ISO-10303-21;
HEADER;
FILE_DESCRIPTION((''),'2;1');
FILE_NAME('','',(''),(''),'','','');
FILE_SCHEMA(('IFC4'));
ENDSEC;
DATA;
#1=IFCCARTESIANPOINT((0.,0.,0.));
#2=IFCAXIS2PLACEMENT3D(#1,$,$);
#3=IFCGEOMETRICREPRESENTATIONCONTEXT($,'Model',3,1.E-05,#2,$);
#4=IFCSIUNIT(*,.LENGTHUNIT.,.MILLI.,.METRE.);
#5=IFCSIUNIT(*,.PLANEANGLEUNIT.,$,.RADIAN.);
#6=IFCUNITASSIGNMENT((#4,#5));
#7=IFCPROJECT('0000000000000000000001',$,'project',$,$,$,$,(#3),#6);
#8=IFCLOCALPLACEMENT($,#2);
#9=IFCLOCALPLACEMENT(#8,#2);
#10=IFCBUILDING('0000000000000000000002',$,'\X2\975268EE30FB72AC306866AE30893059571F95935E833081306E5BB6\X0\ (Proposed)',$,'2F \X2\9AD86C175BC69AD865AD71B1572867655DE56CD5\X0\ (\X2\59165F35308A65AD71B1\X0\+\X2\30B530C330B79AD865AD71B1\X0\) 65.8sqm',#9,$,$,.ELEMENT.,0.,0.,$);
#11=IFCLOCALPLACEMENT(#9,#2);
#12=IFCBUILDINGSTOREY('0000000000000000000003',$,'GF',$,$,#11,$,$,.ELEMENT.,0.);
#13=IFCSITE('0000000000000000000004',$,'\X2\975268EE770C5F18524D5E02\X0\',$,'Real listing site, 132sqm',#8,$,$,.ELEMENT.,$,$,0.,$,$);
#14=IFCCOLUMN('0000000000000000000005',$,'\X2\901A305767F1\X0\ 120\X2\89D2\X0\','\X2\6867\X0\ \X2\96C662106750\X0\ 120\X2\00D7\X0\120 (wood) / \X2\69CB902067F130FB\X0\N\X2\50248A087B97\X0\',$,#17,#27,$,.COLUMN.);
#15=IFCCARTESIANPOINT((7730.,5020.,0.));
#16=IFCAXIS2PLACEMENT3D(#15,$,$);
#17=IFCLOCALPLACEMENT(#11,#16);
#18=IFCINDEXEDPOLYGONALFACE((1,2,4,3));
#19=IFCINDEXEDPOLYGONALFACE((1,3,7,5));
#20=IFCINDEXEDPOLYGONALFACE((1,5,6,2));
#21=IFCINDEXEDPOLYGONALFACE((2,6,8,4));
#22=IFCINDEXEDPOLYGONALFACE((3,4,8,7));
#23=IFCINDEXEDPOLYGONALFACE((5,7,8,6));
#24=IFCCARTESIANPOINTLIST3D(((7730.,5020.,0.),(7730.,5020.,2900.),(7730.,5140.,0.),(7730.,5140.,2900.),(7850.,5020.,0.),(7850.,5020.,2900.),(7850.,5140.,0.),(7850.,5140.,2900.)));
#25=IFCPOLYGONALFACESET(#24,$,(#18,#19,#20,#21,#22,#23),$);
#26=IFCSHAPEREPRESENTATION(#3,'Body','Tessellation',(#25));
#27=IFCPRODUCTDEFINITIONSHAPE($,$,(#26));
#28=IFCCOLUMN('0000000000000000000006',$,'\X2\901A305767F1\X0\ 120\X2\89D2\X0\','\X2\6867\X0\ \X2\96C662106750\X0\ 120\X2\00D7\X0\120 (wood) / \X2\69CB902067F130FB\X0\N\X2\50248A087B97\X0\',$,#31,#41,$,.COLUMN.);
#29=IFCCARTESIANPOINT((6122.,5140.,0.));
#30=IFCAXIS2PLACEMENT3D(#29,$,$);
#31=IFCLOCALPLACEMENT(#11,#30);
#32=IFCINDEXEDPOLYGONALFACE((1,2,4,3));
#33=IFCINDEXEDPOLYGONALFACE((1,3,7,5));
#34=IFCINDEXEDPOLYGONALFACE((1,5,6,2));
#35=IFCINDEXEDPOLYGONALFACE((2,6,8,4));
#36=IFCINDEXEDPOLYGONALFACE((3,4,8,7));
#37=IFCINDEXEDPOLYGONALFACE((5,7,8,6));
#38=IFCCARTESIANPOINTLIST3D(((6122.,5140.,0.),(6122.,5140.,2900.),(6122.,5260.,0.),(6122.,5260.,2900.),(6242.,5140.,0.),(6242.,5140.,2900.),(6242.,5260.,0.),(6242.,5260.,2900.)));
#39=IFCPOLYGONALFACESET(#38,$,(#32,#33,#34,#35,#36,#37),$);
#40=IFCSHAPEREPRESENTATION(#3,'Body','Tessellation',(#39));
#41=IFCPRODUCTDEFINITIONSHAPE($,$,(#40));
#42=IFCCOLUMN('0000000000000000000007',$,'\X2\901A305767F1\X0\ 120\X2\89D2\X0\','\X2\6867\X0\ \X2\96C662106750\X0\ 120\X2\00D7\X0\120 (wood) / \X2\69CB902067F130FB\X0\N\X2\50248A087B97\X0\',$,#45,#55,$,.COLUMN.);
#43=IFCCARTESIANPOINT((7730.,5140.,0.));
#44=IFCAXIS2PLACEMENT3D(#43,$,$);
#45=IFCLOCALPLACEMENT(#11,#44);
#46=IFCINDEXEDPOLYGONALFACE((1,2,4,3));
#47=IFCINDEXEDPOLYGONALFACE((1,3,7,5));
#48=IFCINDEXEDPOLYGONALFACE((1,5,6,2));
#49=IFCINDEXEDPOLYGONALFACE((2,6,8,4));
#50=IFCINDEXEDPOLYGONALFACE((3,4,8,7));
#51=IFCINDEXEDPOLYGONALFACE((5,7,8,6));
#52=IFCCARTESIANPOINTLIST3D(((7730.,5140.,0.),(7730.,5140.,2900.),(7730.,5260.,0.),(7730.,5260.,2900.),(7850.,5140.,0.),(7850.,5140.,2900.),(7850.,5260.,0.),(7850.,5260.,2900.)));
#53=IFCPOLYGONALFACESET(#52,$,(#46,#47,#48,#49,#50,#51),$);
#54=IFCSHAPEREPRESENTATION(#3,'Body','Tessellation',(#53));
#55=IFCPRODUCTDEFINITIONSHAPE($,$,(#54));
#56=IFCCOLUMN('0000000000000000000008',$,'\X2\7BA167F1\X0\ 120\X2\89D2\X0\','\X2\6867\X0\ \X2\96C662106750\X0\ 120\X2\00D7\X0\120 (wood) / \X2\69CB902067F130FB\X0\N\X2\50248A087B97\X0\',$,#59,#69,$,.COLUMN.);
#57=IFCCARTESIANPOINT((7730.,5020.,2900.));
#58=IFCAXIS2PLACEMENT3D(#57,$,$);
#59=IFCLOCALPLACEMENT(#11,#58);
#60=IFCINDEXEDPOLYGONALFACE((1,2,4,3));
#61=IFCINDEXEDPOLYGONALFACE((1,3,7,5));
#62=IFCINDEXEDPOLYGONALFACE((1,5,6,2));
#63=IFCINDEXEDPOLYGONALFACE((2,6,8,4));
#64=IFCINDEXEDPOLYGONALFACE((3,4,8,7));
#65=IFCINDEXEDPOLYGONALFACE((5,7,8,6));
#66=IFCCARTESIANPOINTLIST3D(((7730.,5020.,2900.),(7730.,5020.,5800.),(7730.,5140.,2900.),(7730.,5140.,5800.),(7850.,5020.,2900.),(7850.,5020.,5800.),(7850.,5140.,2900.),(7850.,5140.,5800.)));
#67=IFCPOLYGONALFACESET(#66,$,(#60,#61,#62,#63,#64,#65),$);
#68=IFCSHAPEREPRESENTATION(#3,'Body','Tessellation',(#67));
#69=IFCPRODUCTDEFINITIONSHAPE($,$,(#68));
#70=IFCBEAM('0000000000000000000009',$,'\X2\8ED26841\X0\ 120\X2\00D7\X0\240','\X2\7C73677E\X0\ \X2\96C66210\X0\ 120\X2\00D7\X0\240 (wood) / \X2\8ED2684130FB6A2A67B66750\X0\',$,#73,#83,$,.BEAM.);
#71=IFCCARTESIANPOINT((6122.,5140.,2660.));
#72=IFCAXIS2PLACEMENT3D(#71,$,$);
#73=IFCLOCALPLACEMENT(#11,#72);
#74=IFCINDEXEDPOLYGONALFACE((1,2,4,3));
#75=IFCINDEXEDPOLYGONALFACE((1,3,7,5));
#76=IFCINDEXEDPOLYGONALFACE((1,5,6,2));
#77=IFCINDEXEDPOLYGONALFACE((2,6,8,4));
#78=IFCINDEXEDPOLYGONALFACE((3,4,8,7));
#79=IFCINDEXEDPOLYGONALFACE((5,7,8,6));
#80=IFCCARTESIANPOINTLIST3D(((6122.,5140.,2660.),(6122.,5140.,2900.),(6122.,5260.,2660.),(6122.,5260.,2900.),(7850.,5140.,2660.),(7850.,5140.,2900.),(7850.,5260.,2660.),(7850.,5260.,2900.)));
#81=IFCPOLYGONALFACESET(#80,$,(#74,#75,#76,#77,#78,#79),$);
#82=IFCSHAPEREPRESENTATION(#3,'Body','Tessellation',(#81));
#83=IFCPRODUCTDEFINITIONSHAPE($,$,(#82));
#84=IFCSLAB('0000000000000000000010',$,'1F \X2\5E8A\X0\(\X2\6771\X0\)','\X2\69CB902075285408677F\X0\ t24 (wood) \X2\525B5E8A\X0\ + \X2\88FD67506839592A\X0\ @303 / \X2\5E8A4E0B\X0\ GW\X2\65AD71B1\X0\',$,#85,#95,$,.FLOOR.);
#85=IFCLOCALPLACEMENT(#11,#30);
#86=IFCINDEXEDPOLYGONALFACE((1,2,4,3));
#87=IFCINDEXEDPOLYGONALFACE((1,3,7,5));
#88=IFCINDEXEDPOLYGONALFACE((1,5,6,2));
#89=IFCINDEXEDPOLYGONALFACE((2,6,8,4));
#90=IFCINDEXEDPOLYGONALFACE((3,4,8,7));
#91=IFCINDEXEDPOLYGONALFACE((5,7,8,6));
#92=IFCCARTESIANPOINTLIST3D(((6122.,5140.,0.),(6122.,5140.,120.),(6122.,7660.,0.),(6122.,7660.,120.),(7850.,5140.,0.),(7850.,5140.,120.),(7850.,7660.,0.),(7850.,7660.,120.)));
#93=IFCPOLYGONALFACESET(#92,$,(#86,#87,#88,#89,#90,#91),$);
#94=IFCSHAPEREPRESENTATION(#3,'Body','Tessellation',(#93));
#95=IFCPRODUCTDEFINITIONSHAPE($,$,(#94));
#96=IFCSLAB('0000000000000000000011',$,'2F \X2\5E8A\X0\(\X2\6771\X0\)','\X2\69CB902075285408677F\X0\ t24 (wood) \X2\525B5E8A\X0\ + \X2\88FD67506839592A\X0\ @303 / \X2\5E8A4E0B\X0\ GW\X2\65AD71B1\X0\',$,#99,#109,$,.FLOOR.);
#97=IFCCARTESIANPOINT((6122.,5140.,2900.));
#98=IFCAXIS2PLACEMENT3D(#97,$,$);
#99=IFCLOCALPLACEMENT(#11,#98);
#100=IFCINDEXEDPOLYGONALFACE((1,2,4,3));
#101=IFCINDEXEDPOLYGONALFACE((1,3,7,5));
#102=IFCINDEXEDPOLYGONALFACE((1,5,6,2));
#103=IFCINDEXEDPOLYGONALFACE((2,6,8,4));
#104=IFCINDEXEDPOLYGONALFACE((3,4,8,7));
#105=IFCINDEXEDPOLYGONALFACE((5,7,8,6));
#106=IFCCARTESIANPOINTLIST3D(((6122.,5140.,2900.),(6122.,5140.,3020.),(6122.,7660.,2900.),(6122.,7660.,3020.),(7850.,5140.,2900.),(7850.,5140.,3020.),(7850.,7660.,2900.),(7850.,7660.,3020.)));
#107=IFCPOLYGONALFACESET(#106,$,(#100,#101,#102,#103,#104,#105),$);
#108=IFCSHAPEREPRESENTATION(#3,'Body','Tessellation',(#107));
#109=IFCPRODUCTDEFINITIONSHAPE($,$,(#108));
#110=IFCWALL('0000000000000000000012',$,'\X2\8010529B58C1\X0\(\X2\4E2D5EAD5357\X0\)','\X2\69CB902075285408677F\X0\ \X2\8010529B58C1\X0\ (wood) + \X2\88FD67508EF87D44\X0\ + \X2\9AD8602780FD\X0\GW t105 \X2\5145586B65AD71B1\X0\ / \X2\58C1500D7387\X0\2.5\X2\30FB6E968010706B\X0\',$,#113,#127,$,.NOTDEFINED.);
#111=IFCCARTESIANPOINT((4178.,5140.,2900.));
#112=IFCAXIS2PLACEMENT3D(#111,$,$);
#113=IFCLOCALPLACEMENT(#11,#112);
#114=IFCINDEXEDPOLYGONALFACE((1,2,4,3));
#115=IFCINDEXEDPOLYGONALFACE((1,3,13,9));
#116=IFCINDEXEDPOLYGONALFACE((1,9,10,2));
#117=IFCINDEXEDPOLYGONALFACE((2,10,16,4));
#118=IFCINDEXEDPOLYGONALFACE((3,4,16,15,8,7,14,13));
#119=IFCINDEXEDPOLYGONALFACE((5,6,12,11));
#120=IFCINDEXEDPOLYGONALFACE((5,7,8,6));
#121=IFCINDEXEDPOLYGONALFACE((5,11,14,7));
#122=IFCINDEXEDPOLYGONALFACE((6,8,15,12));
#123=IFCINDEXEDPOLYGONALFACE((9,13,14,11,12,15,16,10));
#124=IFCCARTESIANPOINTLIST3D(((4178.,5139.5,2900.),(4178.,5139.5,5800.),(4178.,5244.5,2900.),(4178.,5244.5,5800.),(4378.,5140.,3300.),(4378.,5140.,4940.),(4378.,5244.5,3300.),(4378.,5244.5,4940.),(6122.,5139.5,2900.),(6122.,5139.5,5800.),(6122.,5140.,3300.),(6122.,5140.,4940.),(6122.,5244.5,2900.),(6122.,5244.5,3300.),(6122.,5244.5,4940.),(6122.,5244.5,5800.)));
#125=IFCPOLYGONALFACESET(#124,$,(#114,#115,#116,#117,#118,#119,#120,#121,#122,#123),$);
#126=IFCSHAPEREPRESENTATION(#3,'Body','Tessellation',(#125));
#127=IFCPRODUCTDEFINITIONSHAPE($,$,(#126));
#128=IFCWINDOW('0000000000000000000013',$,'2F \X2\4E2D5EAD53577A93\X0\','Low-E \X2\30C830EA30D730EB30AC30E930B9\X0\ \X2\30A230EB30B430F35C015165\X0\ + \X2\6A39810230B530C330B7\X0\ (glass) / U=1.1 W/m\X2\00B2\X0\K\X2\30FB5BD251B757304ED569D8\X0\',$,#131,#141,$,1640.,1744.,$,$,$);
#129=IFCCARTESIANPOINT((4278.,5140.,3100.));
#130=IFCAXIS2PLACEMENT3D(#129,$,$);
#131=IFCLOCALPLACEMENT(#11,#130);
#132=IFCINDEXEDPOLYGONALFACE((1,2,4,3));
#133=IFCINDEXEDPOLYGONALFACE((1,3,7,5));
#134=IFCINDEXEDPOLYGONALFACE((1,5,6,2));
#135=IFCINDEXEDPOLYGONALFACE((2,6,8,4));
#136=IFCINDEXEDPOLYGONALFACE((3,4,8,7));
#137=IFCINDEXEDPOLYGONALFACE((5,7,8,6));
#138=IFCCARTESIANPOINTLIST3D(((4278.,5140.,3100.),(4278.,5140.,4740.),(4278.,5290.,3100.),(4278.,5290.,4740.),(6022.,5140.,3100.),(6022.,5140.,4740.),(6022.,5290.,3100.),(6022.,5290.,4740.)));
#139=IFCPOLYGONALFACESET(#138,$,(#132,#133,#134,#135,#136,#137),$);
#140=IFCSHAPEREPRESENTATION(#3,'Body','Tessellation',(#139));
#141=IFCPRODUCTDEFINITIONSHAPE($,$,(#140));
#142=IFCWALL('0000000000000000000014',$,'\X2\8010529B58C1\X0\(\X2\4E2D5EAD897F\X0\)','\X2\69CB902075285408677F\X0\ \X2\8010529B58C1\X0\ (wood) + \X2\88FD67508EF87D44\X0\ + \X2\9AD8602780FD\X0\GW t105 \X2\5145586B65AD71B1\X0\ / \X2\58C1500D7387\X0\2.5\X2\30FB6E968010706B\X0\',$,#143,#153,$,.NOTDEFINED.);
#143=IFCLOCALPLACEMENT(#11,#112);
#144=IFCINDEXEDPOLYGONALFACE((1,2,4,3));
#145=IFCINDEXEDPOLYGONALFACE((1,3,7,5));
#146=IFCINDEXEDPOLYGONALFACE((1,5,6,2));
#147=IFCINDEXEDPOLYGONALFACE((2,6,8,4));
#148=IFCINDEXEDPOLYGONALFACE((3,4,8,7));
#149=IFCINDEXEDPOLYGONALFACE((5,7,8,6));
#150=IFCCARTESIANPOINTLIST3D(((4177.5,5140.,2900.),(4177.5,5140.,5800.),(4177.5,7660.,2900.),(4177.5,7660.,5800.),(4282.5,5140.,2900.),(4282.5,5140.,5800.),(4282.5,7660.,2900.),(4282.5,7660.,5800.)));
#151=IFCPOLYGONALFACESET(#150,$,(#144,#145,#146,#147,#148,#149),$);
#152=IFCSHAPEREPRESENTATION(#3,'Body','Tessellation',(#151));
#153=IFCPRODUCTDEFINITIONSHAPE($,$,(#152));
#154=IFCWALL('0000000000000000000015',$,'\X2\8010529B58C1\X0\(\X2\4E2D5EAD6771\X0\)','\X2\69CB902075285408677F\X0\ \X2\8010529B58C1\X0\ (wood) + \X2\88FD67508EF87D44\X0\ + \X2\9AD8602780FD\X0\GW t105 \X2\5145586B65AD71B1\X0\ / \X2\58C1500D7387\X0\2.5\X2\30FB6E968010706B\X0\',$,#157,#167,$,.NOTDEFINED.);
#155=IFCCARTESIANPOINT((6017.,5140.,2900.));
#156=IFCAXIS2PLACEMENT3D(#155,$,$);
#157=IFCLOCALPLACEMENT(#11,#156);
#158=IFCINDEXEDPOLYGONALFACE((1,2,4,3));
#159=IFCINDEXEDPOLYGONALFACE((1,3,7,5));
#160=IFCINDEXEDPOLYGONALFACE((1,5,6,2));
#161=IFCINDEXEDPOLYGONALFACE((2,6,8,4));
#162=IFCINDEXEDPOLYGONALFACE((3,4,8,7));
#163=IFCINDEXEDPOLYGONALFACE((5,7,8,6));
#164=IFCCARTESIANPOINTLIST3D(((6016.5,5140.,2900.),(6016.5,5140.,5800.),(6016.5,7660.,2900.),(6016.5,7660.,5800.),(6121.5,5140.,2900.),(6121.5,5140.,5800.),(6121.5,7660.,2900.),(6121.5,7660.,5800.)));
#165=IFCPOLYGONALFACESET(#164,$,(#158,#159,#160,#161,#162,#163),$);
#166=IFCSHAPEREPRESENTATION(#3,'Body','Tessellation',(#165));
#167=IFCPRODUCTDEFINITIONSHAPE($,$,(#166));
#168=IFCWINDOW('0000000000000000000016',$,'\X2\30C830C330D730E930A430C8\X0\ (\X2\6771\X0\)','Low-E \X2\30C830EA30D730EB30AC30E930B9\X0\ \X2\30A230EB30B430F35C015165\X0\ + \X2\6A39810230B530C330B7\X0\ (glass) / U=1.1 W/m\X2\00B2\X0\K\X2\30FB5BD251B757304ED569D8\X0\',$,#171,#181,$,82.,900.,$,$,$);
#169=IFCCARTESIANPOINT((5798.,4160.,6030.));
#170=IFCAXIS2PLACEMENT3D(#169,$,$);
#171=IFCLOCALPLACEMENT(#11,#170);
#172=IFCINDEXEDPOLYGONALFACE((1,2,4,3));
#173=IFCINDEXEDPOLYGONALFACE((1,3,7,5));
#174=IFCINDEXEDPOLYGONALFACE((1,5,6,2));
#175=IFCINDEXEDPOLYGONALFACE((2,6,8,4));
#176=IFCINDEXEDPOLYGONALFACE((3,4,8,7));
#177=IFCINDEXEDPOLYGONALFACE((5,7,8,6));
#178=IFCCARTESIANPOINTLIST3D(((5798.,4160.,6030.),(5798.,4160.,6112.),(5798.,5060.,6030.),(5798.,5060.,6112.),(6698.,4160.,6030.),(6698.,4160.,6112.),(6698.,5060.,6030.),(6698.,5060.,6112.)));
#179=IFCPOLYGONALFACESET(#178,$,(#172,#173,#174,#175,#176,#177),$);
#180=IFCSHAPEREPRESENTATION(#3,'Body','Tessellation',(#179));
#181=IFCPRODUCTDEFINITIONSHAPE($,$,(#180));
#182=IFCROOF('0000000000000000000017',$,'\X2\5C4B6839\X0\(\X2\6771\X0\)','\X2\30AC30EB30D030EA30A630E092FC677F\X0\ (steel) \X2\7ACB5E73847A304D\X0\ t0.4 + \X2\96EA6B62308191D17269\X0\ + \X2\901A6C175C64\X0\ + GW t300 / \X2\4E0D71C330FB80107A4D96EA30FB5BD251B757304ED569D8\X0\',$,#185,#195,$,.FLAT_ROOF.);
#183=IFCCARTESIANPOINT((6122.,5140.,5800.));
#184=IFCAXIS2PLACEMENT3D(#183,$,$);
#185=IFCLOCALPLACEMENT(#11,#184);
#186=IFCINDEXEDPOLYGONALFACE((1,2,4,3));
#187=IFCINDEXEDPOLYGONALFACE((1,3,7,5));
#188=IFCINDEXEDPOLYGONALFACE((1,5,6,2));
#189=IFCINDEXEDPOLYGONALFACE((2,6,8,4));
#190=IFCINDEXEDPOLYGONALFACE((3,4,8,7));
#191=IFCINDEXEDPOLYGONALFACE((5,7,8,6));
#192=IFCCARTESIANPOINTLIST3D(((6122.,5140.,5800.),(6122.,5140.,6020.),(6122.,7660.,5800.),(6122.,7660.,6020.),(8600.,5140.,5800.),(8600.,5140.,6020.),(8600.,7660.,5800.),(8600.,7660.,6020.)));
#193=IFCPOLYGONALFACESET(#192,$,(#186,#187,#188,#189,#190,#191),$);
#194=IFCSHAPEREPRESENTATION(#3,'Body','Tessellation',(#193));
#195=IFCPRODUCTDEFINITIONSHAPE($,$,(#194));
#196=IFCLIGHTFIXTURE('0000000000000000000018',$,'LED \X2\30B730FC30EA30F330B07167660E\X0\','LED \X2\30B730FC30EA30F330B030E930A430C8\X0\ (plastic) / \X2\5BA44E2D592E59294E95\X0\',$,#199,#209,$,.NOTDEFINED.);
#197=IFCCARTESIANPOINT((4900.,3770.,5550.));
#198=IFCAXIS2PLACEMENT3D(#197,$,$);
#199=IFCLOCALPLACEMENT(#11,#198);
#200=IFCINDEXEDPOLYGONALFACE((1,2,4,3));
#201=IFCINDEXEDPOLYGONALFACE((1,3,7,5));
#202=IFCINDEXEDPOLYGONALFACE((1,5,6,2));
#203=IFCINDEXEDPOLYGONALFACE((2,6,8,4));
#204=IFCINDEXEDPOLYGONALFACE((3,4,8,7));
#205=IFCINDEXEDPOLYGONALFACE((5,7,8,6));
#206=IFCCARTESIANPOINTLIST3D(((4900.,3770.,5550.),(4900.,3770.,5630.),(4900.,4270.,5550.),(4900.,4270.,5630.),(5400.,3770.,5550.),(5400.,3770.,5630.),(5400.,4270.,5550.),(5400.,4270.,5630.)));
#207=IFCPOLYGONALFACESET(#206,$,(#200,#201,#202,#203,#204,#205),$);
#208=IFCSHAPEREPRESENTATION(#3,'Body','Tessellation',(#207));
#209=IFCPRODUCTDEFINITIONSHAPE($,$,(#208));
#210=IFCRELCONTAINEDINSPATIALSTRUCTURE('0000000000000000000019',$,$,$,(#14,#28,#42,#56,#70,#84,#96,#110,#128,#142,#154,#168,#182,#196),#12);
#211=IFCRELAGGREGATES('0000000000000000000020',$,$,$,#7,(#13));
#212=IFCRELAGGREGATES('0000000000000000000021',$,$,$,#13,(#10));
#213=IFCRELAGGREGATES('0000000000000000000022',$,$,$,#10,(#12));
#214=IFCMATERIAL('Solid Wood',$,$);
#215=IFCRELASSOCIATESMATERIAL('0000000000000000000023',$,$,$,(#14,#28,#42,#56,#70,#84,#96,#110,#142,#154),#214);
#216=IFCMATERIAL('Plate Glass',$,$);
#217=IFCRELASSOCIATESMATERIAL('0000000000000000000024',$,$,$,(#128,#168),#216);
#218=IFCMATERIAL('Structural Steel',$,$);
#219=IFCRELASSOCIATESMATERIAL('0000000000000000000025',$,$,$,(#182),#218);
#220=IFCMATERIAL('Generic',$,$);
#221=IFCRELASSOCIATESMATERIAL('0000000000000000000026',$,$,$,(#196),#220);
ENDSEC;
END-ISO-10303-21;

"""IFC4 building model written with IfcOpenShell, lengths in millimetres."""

from ifc_helpers import new_model, si_unit, frame, frame_2d, origin, place, context, project, spatial, rectangle, extrude, material, element, fill, save


model = new_model("IFC4")

# Units and contexts
model_context = context("Model", 3, precision=1e-05, world=origin())
ifc_project = project(units=[si_unit("LENGTHUNIT", "METRE", prefix="MILLI"), si_unit("PLANEANGLEUNIT", "RADIAN")], contexts=[model_context])

# Site, building, storey
site_placement = place(None, origin())
site = spatial("IfcSite", under=ifc_project, at=site_placement, Name="青森県弘前市", ObjectType="Real listing site, 132sqm", CompositionType="ELEMENT", RefElevation=0.0)
building_placement = place(site_placement, origin())
building = spatial("IfcBuilding", under=site, at=building_placement, Name="青森・犬と暮らす土間広めの家 (Proposed)", ObjectType="2F 高気密高断熱在来工法 (外張り断熱+サッシ高断熱) 65.8sqm", CompositionType="ELEMENT", ElevationOfRefHeight=0.0, ElevationOfTerrain=0.0)
storey_placement = place(building_placement, origin())
storey = spatial("IfcBuildingStorey", under=building, at=storey_placement, Name="GF", CompositionType="ELEMENT", Elevation=0.0)

# Columns
ifc_material_1 = material(Name="Solid Wood")
column_1_placement = place(storey_placement, frame((7730.0, 5020.0, 0.0)))
element("IfcColumn", 1, at=column_1_placement, inside=storey, material=ifc_material_1, Name="通し柱 120角", Description="桧 集成材 120×120 (wood) / 構造柱・N値計算", PredefinedType="COLUMN", context=model_context, shape_type="SweptSolid", body=[
    extrude(rectangle(XDim=120.0, YDim=120.0, at=frame_2d((60.0, 60.0))), frame((7730.0, 5020.0, 0.0)), (0.0, 0.0, 1.0), 2900.0),
])
column_2_placement = place(storey_placement, frame((6122.0, 5140.0, 0.0)))
element("IfcColumn", 2, at=column_2_placement, inside=storey, material=ifc_material_1, Name="通し柱 120角", Description="桧 集成材 120×120 (wood) / 構造柱・N値計算", PredefinedType="COLUMN", context=model_context, shape_type="SweptSolid", body=[
    extrude(rectangle(XDim=120.0, YDim=120.0, at=frame_2d((60.0, 60.0))), frame((6122.0, 5140.0, 0.0)), (0.0, 0.0, 1.0), 2900.0),
])
column_3_placement = place(storey_placement, frame((7730.0, 5140.0, 0.0)))
element("IfcColumn", 3, at=column_3_placement, inside=storey, material=ifc_material_1, Name="通し柱 120角", Description="桧 集成材 120×120 (wood) / 構造柱・N値計算", PredefinedType="COLUMN", context=model_context, shape_type="SweptSolid", body=[
    extrude(rectangle(XDim=120.0, YDim=120.0, at=frame_2d((60.0, 60.0))), frame((7730.0, 5140.0, 0.0)), (0.0, 0.0, 1.0), 2900.0),
])
column_4_placement = place(storey_placement, frame((7730.0, 5020.0, 2900.0)))
element("IfcColumn", 4, at=column_4_placement, inside=storey, material=ifc_material_1, Name="管柱 120角", Description="桧 集成材 120×120 (wood) / 構造柱・N値計算", PredefinedType="COLUMN", context=model_context, shape_type="SweptSolid", body=[
    extrude(rectangle(XDim=120.0, YDim=120.0, at=frame_2d((60.0, 60.0))), frame((7730.0, 5020.0, 2900.0)), (0.0, 0.0, 1.0), 2900.0),
])

# Beam
beam_1_placement = place(storey_placement, frame((6122.0, 5140.0, 2660.0)))
element("IfcBeam", 5, at=beam_1_placement, inside=storey, material=ifc_material_1, Name="軒桁 120×240", Description="米松 集成 120×240 (wood) / 軒桁・横架材", PredefinedType="BEAM", context=model_context, shape_type="SweptSolid", body=[
    extrude(rectangle(XDim=1728.0, YDim=120.0, at=frame_2d((864.0, 60.0))), frame((6122.0, 5140.0, 2660.0)), (0.0, 0.0, 1.0), 240.0),
])

# Slabs
slab_1_placement = place(storey_placement, frame((6122.0, 5140.0, 0.0)))
element("IfcSlab", 6, at=slab_1_placement, inside=storey, material=ifc_material_1, Name="1F 床(東)", Description="構造用合板 t24 (wood) 剛床 + 製材根太 @303 / 床下 GW断熱", PredefinedType="FLOOR", context=model_context, shape_type="SweptSolid", body=[
    extrude(rectangle(XDim=1728.0, YDim=2520.0, at=frame_2d((864.0, 1260.0))), frame((6122.0, 5140.0, 0.0)), (0.0, 0.0, 1.0), 120.0),
])
slab_2_placement = place(storey_placement, frame((6122.0, 5140.0, 2900.0)))
element("IfcSlab", 7, at=slab_2_placement, inside=storey, material=ifc_material_1, Name="2F 床(東)", Description="構造用合板 t24 (wood) 剛床 + 製材根太 @303 / 床下 GW断熱", PredefinedType="FLOOR", context=model_context, shape_type="SweptSolid", body=[
    extrude(rectangle(XDim=1728.0, YDim=2520.0, at=frame_2d((864.0, 1260.0))), frame((6122.0, 5140.0, 2900.0)), (0.0, 0.0, 1.0), 120.0),
])

# Wall, opening, window
wall_1_placement = place(storey_placement, frame((4178.0, 5140.0, 2900.0)))
wall_1 = element("IfcWall", 8, at=wall_1_placement, inside=storey, material=ifc_material_1, Name="耐力壁(中庭南)", Description="構造用合板 耐力壁 (wood) + 製材軸組 + 高性能GW t105 充填断熱 / 壁倍率2.5・準耐火", PredefinedType="NOTDEFINED", context=model_context, shape_type="SweptSolid", body=[
    extrude(rectangle(XDim=1944.0, YDim=105.0, at=frame_2d((972.0, 52.0))), frame((4178.0, 5140.0, 2900.0)), (0.0, 0.0, 1.0), 2900.0),
])
opening_placement = place(storey_placement, frame((4278.0, 5140.0, 3100.0)))
opening = element("IfcOpeningElement", 9, at=opening_placement, cuts=wall_1, PredefinedType="NOTDEFINED", context=model_context, shape_type="SweptSolid", body=[
    extrude(rectangle(XDim=1744.0, YDim=150.0, at=frame_2d((872.0, 75.0))), frame((4278.0, 5140.0, 3100.0)), (0.0, 0.0, 1.0), 1640.0),
])
ifc_material_2 = material(Name="Plate Glass")
window_1_placement = place(storey_placement, frame((4278.0, 5140.0, 3100.0)))
window_1 = element("IfcWindow", 10, at=window_1_placement, inside=storey, material=ifc_material_2, Name="2F 中庭南窓", Description="Low-E トリプルガラス アルゴン封入 + 樹脂サッシ (glass) / U=1.1 W/m²K・寒冷地仕様", OverallHeight=1640.0, OverallWidth=1744.0, context=model_context, shape_type="SweptSolid", body=[
    extrude(rectangle(XDim=1744.0, YDim=150.0, at=frame_2d((872.0, 75.0))), frame((4278.0, 5140.0, 3100.0)), (0.0, 0.0, 1.0), 1640.0),
])
fill(opening, window_1)

# Walls
wall_2_placement = place(storey_placement, frame((4178.0, 5140.0, 2900.0)))
element("IfcWall", 11, at=wall_2_placement, inside=storey, material=ifc_material_1, Name="耐力壁(中庭西)", Description="構造用合板 耐力壁 (wood) + 製材軸組 + 高性能GW t105 充填断熱 / 壁倍率2.5・準耐火", PredefinedType="NOTDEFINED", context=model_context, shape_type="SweptSolid", body=[
    extrude(rectangle(XDim=105.0, YDim=2520.0, at=frame_2d((52.0, 1260.0))), frame((4178.0, 5140.0, 2900.0)), (0.0, 0.0, 1.0), 2900.0),
])
wall_3_placement = place(storey_placement, frame((6017.0, 5140.0, 2900.0)))
element("IfcWall", 12, at=wall_3_placement, inside=storey, material=ifc_material_1, Name="耐力壁(中庭東)", Description="構造用合板 耐力壁 (wood) + 製材軸組 + 高性能GW t105 充填断熱 / 壁倍率2.5・準耐火", PredefinedType="NOTDEFINED", context=model_context, shape_type="SweptSolid", body=[
    extrude(rectangle(XDim=105.0, YDim=2520.0, at=frame_2d((52.0, 1260.0))), frame((6017.0, 5140.0, 2900.0)), (0.0, 0.0, 1.0), 2900.0),
])

# Window
window_2_placement = place(storey_placement, frame((5798.0, 4160.0, 6030.0)))
element("IfcWindow", 13, at=window_2_placement, inside=storey, material=ifc_material_2, Name="トップライト (東)", Description="Low-E トリプルガラス アルゴン封入 + 樹脂サッシ (glass) / U=1.1 W/m²K・寒冷地仕様", OverallHeight=82.0, OverallWidth=900.0, context=model_context, shape_type="SweptSolid", body=[
    extrude(rectangle(XDim=900.0, YDim=900.0, at=frame_2d((450.0, 450.0))), frame((5798.0, 4160.0, 6030.0)), (0.0, 0.0, 1.0), 82.0),
])

# Roof
ifc_material_3 = material(Name="Structural Steel")
for number, where, name in (
    (14, (6122.0, 5140.0, 5800.0), "屋根(東)"),
):
    element("IfcRoof", number, at=place(storey_placement, frame(where)), inside=storey, material=ifc_material_3, Name=name, Description="ガルバリウム鋼板 (steel) 立平葺き t0.4 + 雪止め金物 + 通気層 + GW t300 / 不燃・耐積雪・寒冷地仕様", PredefinedType="FLAT_ROOF", context=model_context, shape_type="SweptSolid", body=[
        extrude(rectangle(XDim=2478.0, YDim=2520.0, at=frame_2d((1239.0, 1260.0))), frame((6122.0, 5140.0, 5800.0)), (0.0, 0.0, 1.0), 220.0),
    ])

# Light fixture
ifc_material_4 = material(Name="Generic")
light_fixture_placement = place(storey_placement, frame((4900.0, 3770.0, 5550.0)))
element("IfcLightFixture", 15, at=light_fixture_placement, inside=storey, material=ifc_material_4, Name="LED シーリング照明", Description="LED シーリングライト (plastic) / 室中央天井", PredefinedType="NOTDEFINED", context=model_context, shape_type="SweptSolid", body=[
    extrude(rectangle(XDim=500.0, YDim=500.0, at=frame_2d((250.0, 250.0))), frame((4900.0, 3770.0, 5550.0)), (0.0, 0.0, 1.0), 80.0),
])

save(model, "model.ifc")
